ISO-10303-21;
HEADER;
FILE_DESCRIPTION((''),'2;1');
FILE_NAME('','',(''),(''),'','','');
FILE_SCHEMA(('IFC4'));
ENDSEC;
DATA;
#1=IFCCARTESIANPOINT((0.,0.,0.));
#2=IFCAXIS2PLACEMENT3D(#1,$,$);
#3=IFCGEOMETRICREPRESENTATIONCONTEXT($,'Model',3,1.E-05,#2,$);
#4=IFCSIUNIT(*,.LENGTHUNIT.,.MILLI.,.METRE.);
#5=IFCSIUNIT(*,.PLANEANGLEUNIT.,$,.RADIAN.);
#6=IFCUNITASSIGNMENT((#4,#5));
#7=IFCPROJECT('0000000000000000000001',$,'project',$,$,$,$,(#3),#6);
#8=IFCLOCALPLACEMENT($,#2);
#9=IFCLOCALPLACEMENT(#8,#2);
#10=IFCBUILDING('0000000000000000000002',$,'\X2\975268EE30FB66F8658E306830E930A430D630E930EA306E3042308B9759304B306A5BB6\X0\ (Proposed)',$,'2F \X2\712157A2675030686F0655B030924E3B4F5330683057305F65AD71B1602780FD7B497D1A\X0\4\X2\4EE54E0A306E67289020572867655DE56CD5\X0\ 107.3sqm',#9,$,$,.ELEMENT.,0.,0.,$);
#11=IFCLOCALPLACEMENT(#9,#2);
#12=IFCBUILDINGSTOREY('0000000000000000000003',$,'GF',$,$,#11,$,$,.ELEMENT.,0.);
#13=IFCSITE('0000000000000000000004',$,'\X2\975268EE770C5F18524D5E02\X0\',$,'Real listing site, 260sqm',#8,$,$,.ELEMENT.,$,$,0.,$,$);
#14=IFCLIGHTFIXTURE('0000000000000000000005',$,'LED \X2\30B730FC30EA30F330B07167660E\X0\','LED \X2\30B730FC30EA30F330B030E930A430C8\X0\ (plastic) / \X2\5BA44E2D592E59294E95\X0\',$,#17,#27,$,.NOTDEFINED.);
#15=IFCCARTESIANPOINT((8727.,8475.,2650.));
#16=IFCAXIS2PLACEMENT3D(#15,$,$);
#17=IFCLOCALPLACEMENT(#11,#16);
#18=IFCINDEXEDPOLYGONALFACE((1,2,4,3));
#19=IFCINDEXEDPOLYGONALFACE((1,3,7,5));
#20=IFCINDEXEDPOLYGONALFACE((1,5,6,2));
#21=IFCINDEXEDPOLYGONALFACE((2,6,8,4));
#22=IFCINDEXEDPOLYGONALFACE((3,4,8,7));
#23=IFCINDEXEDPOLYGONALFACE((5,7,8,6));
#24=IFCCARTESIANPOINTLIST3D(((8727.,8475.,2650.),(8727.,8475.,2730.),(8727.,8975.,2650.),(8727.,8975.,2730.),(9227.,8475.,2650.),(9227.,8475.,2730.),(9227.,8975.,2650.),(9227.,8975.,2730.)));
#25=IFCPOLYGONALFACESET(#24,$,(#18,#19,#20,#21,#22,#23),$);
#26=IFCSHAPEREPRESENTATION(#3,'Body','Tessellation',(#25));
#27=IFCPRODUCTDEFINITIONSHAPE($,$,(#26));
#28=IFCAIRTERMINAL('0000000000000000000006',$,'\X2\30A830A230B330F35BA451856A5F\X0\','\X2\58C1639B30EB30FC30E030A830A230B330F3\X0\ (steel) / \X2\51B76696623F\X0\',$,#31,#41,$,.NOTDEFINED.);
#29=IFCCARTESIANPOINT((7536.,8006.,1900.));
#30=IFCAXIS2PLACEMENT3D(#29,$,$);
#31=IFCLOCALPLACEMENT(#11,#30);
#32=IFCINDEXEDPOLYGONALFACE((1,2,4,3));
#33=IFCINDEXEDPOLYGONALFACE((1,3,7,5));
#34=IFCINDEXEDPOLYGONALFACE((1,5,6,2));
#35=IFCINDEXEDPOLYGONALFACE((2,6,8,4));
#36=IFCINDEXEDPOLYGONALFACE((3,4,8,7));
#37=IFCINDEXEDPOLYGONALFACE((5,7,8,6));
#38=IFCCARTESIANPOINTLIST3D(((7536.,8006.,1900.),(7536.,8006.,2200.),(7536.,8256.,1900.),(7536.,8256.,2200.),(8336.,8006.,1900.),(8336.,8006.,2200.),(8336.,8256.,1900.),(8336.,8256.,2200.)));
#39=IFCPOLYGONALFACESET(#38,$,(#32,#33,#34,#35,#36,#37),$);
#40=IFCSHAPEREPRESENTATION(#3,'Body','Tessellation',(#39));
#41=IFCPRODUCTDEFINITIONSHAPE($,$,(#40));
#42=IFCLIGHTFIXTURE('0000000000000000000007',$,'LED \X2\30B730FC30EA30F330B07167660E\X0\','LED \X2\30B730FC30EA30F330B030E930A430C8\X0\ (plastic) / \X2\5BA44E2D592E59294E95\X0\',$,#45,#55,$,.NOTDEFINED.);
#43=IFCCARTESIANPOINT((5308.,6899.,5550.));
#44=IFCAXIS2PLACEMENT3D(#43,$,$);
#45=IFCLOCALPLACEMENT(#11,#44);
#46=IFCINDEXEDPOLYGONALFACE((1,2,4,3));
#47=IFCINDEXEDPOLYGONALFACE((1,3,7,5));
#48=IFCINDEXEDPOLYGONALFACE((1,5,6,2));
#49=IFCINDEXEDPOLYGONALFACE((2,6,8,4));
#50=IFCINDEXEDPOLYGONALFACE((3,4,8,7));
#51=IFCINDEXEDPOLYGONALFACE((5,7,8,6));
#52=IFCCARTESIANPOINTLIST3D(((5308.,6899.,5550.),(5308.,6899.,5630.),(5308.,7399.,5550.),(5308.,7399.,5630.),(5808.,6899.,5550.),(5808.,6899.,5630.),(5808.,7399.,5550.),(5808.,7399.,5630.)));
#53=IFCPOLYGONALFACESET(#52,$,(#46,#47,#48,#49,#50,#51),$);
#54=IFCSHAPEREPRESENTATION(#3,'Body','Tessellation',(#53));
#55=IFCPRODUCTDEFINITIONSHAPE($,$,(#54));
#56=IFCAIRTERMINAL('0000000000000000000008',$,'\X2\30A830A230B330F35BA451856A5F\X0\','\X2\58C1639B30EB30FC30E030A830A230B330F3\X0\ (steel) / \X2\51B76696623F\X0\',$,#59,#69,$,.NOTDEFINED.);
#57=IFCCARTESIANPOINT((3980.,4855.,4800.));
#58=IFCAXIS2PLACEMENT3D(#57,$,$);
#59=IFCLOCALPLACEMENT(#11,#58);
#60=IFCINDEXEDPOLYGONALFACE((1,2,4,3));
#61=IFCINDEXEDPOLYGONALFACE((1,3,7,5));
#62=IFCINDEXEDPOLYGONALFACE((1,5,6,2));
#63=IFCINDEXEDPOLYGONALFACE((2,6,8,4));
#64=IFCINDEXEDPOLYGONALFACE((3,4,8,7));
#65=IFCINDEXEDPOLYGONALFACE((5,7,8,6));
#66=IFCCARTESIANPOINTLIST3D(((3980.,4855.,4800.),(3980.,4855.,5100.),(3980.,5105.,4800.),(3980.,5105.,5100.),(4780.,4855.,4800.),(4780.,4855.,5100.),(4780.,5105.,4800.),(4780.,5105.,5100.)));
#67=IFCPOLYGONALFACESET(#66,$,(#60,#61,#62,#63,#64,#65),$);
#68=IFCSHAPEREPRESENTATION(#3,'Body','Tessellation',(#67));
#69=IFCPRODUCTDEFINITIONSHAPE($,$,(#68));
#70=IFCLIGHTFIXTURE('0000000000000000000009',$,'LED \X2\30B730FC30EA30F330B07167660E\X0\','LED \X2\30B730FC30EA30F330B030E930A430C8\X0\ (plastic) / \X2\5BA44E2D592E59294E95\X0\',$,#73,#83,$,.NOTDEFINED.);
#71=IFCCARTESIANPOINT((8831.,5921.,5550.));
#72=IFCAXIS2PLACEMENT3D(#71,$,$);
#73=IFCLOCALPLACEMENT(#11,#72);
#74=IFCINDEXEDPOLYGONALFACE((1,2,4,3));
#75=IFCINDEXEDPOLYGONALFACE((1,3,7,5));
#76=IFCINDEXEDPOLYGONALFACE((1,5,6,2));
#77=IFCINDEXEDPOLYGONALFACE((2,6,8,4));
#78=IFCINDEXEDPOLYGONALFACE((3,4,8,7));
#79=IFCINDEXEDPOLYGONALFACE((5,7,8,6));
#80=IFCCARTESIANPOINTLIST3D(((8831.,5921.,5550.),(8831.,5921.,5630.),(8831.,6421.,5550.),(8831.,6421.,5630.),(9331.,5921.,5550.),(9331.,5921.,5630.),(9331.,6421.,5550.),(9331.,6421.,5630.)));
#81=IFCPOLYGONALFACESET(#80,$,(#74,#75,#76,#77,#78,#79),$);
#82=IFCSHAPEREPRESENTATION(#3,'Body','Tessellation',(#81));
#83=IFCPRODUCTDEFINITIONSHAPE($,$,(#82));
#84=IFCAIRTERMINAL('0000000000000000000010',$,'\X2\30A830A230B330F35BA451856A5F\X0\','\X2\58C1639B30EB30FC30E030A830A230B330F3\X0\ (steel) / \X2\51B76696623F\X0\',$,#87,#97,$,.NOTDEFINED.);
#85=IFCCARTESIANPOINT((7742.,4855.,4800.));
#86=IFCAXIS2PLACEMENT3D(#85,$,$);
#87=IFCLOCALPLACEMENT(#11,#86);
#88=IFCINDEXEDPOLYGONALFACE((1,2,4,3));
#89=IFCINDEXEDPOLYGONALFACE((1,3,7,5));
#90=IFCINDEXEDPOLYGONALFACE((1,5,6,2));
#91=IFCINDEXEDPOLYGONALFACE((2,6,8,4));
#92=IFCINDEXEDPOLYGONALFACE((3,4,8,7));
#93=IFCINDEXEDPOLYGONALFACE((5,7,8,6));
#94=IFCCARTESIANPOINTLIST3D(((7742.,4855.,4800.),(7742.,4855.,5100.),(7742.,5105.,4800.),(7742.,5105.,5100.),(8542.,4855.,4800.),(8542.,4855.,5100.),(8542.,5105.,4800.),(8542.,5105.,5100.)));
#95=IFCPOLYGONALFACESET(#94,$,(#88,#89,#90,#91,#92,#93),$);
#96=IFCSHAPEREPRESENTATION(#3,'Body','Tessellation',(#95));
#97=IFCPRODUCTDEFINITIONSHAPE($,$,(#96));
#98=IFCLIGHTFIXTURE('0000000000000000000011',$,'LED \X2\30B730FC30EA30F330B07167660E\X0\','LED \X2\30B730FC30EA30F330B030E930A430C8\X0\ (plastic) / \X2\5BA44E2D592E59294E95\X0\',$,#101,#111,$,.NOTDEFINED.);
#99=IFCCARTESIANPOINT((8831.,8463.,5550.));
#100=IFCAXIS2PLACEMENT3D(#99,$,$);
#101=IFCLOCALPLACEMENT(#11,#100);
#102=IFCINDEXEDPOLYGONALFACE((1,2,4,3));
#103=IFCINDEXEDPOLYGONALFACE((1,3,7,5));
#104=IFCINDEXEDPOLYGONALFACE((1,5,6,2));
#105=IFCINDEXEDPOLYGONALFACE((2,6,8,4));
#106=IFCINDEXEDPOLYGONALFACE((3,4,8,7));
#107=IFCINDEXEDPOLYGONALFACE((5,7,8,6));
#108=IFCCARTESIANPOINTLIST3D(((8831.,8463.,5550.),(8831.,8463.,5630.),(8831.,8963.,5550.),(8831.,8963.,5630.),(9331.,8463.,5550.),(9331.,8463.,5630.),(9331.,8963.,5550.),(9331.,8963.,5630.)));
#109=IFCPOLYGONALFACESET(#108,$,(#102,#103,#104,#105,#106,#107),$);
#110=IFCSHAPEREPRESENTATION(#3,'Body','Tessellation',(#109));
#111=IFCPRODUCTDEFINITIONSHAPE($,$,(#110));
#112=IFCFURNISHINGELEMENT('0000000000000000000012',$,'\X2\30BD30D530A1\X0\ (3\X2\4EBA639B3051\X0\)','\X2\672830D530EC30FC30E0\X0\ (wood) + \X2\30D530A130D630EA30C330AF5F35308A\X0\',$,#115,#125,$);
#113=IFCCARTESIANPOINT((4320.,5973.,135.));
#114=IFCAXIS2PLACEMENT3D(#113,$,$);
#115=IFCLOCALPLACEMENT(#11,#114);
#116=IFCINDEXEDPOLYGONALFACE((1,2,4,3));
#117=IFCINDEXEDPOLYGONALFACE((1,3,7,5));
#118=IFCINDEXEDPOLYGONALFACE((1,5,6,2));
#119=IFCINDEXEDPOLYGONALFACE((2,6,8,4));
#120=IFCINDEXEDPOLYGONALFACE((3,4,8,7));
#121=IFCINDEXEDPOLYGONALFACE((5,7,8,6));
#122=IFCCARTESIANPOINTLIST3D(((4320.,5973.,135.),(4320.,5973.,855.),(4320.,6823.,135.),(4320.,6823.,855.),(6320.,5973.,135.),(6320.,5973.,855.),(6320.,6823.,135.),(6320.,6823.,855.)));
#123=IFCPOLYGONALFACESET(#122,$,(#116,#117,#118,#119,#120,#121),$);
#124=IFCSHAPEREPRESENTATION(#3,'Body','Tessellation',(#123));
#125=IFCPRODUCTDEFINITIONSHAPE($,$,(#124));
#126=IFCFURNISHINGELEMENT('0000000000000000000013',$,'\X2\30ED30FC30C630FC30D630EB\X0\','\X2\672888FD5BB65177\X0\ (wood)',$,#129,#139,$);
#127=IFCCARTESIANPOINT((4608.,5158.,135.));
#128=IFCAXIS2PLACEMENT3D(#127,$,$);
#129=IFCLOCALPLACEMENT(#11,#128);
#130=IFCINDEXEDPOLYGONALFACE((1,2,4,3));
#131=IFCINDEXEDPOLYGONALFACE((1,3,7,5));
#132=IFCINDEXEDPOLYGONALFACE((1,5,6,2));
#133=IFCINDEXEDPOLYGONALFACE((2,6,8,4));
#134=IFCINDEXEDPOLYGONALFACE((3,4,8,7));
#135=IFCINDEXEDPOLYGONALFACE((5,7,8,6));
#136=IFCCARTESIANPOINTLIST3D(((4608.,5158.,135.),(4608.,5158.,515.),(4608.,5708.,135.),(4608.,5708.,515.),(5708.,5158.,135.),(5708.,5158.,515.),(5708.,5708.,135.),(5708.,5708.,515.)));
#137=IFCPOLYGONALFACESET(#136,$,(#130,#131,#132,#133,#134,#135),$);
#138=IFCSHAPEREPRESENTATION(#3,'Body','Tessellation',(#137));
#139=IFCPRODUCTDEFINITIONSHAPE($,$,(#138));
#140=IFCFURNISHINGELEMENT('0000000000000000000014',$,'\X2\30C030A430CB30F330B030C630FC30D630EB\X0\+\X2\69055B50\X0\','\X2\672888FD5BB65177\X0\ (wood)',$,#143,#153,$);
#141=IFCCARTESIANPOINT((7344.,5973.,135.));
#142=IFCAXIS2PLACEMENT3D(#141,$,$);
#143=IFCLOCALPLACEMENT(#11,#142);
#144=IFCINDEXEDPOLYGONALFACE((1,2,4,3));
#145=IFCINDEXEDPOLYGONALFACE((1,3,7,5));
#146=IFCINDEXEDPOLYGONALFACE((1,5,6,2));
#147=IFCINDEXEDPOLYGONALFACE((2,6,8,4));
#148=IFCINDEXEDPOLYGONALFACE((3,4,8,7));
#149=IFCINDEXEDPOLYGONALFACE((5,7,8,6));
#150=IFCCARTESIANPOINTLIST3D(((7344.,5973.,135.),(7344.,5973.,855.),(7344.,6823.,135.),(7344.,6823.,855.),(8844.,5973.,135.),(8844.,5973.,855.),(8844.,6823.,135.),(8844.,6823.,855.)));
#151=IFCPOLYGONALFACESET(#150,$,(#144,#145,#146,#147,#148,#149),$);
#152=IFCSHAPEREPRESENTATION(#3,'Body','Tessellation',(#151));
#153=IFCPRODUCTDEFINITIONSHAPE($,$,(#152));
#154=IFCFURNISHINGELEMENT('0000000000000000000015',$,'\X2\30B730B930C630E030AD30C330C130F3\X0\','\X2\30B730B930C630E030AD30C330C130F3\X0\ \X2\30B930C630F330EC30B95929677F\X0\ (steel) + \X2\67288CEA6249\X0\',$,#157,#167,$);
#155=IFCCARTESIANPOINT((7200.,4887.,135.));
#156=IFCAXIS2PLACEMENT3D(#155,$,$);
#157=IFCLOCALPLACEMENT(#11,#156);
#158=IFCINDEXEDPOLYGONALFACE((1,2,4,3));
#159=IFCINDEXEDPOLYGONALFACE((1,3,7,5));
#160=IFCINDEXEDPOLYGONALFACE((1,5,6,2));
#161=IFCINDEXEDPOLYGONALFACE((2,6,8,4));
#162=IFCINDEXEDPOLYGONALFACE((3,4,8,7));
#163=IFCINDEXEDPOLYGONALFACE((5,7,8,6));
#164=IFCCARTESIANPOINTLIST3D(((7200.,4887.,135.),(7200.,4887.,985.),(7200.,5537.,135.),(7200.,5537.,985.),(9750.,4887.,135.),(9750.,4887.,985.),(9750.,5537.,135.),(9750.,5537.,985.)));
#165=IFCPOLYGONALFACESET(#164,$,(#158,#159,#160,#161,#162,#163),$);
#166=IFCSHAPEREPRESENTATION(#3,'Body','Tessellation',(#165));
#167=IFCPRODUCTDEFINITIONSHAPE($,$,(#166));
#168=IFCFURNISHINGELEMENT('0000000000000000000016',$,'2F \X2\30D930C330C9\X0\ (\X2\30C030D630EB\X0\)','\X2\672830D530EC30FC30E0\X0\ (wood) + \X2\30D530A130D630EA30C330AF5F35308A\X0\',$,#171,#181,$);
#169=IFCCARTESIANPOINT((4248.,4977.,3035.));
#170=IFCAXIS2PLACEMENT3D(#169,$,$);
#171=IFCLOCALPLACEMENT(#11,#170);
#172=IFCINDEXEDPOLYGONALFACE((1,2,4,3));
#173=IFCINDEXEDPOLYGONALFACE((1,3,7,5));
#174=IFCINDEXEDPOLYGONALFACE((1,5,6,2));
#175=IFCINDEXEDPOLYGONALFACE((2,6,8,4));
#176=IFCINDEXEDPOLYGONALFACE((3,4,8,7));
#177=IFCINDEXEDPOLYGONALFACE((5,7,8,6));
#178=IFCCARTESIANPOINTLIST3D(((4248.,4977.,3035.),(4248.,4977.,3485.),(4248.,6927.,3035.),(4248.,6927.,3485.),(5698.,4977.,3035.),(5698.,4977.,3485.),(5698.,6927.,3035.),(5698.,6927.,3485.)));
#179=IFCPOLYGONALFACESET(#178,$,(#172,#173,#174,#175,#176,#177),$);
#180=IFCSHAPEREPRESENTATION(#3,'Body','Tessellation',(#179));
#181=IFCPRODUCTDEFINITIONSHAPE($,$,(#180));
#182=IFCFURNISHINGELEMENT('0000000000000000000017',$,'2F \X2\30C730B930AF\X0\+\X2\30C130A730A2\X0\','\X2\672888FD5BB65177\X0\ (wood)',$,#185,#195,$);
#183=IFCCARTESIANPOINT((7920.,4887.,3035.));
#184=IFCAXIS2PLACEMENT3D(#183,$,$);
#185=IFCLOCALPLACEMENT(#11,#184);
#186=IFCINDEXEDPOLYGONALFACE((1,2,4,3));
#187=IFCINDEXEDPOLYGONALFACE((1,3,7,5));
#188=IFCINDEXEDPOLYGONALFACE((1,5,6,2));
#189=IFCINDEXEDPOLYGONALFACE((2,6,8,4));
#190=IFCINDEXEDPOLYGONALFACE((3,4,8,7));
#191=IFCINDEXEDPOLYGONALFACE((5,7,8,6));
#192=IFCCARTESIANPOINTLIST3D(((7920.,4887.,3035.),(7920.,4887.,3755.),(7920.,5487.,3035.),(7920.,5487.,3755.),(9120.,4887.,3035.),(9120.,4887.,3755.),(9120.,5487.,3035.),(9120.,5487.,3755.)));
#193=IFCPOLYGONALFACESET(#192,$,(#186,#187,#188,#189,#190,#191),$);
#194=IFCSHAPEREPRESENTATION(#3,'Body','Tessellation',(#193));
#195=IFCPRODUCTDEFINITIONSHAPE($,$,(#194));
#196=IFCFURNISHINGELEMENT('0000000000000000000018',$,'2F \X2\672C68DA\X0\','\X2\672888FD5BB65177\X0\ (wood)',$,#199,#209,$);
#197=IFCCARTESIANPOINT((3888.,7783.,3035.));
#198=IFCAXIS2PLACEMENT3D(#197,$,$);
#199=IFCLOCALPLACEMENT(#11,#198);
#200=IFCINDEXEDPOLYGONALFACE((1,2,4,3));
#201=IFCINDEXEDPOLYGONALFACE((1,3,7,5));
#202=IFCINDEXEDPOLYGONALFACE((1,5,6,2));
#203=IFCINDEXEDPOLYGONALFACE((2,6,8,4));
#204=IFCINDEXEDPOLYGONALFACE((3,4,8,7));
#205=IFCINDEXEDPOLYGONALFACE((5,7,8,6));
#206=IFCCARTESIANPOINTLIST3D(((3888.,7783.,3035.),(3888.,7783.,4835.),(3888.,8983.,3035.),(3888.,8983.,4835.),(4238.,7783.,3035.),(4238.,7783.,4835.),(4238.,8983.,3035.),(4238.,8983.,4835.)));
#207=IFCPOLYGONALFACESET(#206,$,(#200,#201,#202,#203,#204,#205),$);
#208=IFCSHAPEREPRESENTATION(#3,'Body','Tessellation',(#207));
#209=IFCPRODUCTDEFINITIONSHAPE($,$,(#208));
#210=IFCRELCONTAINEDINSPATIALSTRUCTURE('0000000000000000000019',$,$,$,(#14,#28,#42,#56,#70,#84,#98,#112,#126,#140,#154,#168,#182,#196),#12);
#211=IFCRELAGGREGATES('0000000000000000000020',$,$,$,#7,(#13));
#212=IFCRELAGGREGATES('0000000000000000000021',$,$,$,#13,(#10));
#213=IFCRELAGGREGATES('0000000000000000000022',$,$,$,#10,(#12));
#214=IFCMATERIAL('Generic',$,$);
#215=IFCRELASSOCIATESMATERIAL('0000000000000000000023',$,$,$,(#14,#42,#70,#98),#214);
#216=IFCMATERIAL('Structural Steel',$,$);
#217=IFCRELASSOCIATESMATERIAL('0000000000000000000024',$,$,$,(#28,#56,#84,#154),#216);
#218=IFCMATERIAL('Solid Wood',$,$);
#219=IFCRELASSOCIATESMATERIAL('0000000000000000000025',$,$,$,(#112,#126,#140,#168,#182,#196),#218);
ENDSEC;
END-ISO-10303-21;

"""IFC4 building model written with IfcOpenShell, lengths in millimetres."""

from ifc_helpers import new_model, si_unit, frame, frame_2d, origin, place, context, project, spatial, rectangle, extrude, material, element, save


model = new_model("IFC4")

# Units and contexts
model_context = context("Model", 3, precision=1e-05, world=origin())
ifc_project = project(units=[si_unit("LENGTHUNIT", "METRE", prefix="MILLI"), si_unit("PLANEANGLEUNIT", "RADIAN")], contexts=[model_context])

# Site, building, storey
site_placement = place(None, origin())
site = spatial("IfcSite", under=ifc_project, at=site_placement, Name="青森県弘前市", ObjectType="Real listing site, 260sqm", CompositionType="ELEMENT", RefElevation=0.0)
building_placement = place(site_placement, origin())
building = spatial("IfcBuilding", under=site, at=building_placement, Name="青森・書斎とライブラリのある静かな家 (Proposed)", ObjectType="2F 無垢材と漆喰を主体とした断熱性能等級4以上の木造在来工法 107.3sqm", CompositionType="ELEMENT", ElevationOfRefHeight=0.0, ElevationOfTerrain=0.0)
storey_placement = place(building_placement, origin())
storey = spatial("IfcBuildingStorey", under=building, at=storey_placement, Name="GF", CompositionType="ELEMENT", Elevation=0.0)

# Shared definitions
ifc_material_1 = material(Name="Solid Wood")

# Shared definitions
ifc_material_2 = material(Name="Structural Steel")

# Shared definitions
ifc_material_3 = material(Name="Generic")

# Light fixture
light_fixture_1_placement = place(storey_placement, frame((8727.0, 8475.0, 2650.0)))
element("IfcLightFixture", 1, at=light_fixture_1_placement, inside=storey, material=ifc_material_3, Name="LED シーリング照明", Description="LED シーリングライト (plastic) / 室中央天井", PredefinedType="NOTDEFINED", context=model_context, shape_type="SweptSolid", body=[
    extrude(rectangle(XDim=500.0, YDim=500.0, at=frame_2d((250.0, 250.0))), frame((8727.0, 8475.0, 2650.0)), (0.0, 0.0, 1.0), 80.0),
])

# Air terminal
air_terminal_1_placement = place(storey_placement, frame((7536.0, 8006.0, 1900.0)))
element("IfcAirTerminal", 2, at=air_terminal_1_placement, inside=storey, material=ifc_material_2, Name="エアコン室内機", Description="壁掛ルームエアコン (steel) / 冷暖房", PredefinedType="NOTDEFINED", context=model_context, shape_type="SweptSolid", body=[
    extrude(rectangle(XDim=800.0, YDim=250.0, at=frame_2d((400.0, 125.0))), frame((7536.0, 8006.0, 1900.0)), (0.0, 0.0, 1.0), 300.0),
])

# Light fixture
light_fixture_2_placement = place(storey_placement, frame((5308.0, 6899.0, 5550.0)))
element("IfcLightFixture", 3, at=light_fixture_2_placement, inside=storey, material=ifc_material_3, Name="LED シーリング照明", Description="LED シーリングライト (plastic) / 室中央天井", PredefinedType="NOTDEFINED", context=model_context, shape_type="SweptSolid", body=[
    extrude(rectangle(XDim=500.0, YDim=500.0, at=frame_2d((250.0, 250.0))), frame((5308.0, 6899.0, 5550.0)), (0.0, 0.0, 1.0), 80.0),
])

# Air terminal
air_terminal_2_placement = place(storey_placement, frame((3980.0, 4855.0, 4800.0)))
element("IfcAirTerminal", 4, at=air_terminal_2_placement, inside=storey, material=ifc_material_2, Name="エアコン室内機", Description="壁掛ルームエアコン (steel) / 冷暖房", PredefinedType="NOTDEFINED", context=model_context, shape_type="SweptSolid", body=[
    extrude(rectangle(XDim=800.0, YDim=250.0, at=frame_2d((400.0, 125.0))), frame((3980.0, 4855.0, 4800.0)), (0.0, 0.0, 1.0), 300.0),
])

# Light fixture
light_fixture_3_placement = place(storey_placement, frame((8831.0, 5921.0, 5550.0)))
element("IfcLightFixture", 5, at=light_fixture_3_placement, inside=storey, material=ifc_material_3, Name="LED シーリング照明", Description="LED シーリングライト (plastic) / 室中央天井", PredefinedType="NOTDEFINED", context=model_context, shape_type="SweptSolid", body=[
    extrude(rectangle(XDim=500.0, YDim=500.0, at=frame_2d((250.0, 250.0))), frame((8831.0, 5921.0, 5550.0)), (0.0, 0.0, 1.0), 80.0),
])

# Air terminal
air_terminal_3_placement = place(storey_placement, frame((7742.0, 4855.0, 4800.0)))
element("IfcAirTerminal", 6, at=air_terminal_3_placement, inside=storey, material=ifc_material_2, Name="エアコン室内機", Description="壁掛ルームエアコン (steel) / 冷暖房", PredefinedType="NOTDEFINED", context=model_context, shape_type="SweptSolid", body=[
    extrude(rectangle(XDim=800.0, YDim=250.0, at=frame_2d((400.0, 125.0))), frame((7742.0, 4855.0, 4800.0)), (0.0, 0.0, 1.0), 300.0),
])

# Light fixture
light_fixture_4_placement = place(storey_placement, frame((8831.0, 8463.0, 5550.0)))
element("IfcLightFixture", 7, at=light_fixture_4_placement, inside=storey, material=ifc_material_3, Name="LED シーリング照明", Description="LED シーリングライト (plastic) / 室中央天井", PredefinedType="NOTDEFINED", context=model_context, shape_type="SweptSolid", body=[
    extrude(rectangle(XDim=500.0, YDim=500.0, at=frame_2d((250.0, 250.0))), frame((8831.0, 8463.0, 5550.0)), (0.0, 0.0, 1.0), 80.0),
])

# Furnishing elements
furnishing_1_placement = place(storey_placement, frame((4320.0, 5973.0, 135.0)))
element("IfcFurnishingElement", 8, at=furnishing_1_placement, inside=storey, material=ifc_material_1, Name="ソファ (3人掛け)", Description="木フレーム (wood) + ファブリック張り", context=model_context, shape_type="SweptSolid", body=[
    extrude(rectangle(XDim=2000.0, YDim=850.0, at=frame_2d((1000.0, 425.0))), frame((4320.0, 5973.0, 135.0)), (0.0, 0.0, 1.0), 720.0),
])
furnishing_2_placement = place(storey_placement, frame((4608.0, 5158.0, 135.0)))
element("IfcFurnishingElement", 9, at=furnishing_2_placement, inside=storey, material=ifc_material_1, Name="ローテーブル", Description="木製家具 (wood)", context=model_context, shape_type="SweptSolid", body=[
    extrude(rectangle(XDim=1100.0, YDim=550.0, at=frame_2d((550.0, 275.0))), frame((4608.0, 5158.0, 135.0)), (0.0, 0.0, 1.0), 380.0),
])
furnishing_3_placement = place(storey_placement, frame((7344.0, 5973.0, 135.0)))
element("IfcFurnishingElement", 10, at=furnishing_3_placement, inside=storey, material=ifc_material_1, Name="ダイニングテーブル+椅子", Description="木製家具 (wood)", context=model_context, shape_type="SweptSolid", body=[
    extrude(rectangle(XDim=1500.0, YDim=850.0, at=frame_2d((750.0, 425.0))), frame((7344.0, 5973.0, 135.0)), (0.0, 0.0, 1.0), 720.0),
])
furnishing_4_placement = place(storey_placement, frame((7200.0, 4887.0, 135.0)))
element("IfcFurnishingElement", 11, at=furnishing_4_placement, inside=storey, material=ifc_material_2, Name="システムキッチン", Description="システムキッチン ステンレス天板 (steel) + 木質扉", context=model_context, shape_type="SweptSolid", body=[
    extrude(rectangle(XDim=2550.0, YDim=650.0, at=frame_2d((1275.0, 325.0))), frame((7200.0, 4887.0, 135.0)), (0.0, 0.0, 1.0), 850.0),
])
furnishing_5_placement = place(storey_placement, frame((4248.0, 4977.0, 3035.0)))
element("IfcFurnishingElement", 12, at=furnishing_5_placement, inside=storey, material=ifc_material_1, Name="2F ベッド (ダブル)", Description="木フレーム (wood) + ファブリック張り", context=model_context, shape_type="SweptSolid", body=[
    extrude(rectangle(XDim=1450.0, YDim=1950.0, at=frame_2d((725.0, 975.0))), frame((4248.0, 4977.0, 3035.0)), (0.0, 0.0, 1.0), 450.0),
])
furnishing_6_placement = place(storey_placement, frame((7920.0, 4887.0, 3035.0)))
element("IfcFurnishingElement", 13, at=furnishing_6_placement, inside=storey, material=ifc_material_1, Name="2F デスク+チェア", Description="木製家具 (wood)", context=model_context, shape_type="SweptSolid", body=[
    extrude(rectangle(XDim=1200.0, YDim=600.0, at=frame_2d((600.0, 300.0))), frame((7920.0, 4887.0, 3035.0)), (0.0, 0.0, 1.0), 720.0),
])
furnishing_7_placement = place(storey_placement, frame((3888.0, 7783.0, 3035.0)))
element("IfcFurnishingElement", 14, at=furnishing_7_placement, inside=storey, material=ifc_material_1, Name="2F 本棚", Description="木製家具 (wood)", context=model_context, shape_type="SweptSolid", body=[
    extrude(rectangle(XDim=350.0, YDim=1200.0, at=frame_2d((175.0, 600.0))), frame((3888.0, 7783.0, 3035.0)), (0.0, 0.0, 1.0), 1800.0),
])

save(model, "model.ifc")
